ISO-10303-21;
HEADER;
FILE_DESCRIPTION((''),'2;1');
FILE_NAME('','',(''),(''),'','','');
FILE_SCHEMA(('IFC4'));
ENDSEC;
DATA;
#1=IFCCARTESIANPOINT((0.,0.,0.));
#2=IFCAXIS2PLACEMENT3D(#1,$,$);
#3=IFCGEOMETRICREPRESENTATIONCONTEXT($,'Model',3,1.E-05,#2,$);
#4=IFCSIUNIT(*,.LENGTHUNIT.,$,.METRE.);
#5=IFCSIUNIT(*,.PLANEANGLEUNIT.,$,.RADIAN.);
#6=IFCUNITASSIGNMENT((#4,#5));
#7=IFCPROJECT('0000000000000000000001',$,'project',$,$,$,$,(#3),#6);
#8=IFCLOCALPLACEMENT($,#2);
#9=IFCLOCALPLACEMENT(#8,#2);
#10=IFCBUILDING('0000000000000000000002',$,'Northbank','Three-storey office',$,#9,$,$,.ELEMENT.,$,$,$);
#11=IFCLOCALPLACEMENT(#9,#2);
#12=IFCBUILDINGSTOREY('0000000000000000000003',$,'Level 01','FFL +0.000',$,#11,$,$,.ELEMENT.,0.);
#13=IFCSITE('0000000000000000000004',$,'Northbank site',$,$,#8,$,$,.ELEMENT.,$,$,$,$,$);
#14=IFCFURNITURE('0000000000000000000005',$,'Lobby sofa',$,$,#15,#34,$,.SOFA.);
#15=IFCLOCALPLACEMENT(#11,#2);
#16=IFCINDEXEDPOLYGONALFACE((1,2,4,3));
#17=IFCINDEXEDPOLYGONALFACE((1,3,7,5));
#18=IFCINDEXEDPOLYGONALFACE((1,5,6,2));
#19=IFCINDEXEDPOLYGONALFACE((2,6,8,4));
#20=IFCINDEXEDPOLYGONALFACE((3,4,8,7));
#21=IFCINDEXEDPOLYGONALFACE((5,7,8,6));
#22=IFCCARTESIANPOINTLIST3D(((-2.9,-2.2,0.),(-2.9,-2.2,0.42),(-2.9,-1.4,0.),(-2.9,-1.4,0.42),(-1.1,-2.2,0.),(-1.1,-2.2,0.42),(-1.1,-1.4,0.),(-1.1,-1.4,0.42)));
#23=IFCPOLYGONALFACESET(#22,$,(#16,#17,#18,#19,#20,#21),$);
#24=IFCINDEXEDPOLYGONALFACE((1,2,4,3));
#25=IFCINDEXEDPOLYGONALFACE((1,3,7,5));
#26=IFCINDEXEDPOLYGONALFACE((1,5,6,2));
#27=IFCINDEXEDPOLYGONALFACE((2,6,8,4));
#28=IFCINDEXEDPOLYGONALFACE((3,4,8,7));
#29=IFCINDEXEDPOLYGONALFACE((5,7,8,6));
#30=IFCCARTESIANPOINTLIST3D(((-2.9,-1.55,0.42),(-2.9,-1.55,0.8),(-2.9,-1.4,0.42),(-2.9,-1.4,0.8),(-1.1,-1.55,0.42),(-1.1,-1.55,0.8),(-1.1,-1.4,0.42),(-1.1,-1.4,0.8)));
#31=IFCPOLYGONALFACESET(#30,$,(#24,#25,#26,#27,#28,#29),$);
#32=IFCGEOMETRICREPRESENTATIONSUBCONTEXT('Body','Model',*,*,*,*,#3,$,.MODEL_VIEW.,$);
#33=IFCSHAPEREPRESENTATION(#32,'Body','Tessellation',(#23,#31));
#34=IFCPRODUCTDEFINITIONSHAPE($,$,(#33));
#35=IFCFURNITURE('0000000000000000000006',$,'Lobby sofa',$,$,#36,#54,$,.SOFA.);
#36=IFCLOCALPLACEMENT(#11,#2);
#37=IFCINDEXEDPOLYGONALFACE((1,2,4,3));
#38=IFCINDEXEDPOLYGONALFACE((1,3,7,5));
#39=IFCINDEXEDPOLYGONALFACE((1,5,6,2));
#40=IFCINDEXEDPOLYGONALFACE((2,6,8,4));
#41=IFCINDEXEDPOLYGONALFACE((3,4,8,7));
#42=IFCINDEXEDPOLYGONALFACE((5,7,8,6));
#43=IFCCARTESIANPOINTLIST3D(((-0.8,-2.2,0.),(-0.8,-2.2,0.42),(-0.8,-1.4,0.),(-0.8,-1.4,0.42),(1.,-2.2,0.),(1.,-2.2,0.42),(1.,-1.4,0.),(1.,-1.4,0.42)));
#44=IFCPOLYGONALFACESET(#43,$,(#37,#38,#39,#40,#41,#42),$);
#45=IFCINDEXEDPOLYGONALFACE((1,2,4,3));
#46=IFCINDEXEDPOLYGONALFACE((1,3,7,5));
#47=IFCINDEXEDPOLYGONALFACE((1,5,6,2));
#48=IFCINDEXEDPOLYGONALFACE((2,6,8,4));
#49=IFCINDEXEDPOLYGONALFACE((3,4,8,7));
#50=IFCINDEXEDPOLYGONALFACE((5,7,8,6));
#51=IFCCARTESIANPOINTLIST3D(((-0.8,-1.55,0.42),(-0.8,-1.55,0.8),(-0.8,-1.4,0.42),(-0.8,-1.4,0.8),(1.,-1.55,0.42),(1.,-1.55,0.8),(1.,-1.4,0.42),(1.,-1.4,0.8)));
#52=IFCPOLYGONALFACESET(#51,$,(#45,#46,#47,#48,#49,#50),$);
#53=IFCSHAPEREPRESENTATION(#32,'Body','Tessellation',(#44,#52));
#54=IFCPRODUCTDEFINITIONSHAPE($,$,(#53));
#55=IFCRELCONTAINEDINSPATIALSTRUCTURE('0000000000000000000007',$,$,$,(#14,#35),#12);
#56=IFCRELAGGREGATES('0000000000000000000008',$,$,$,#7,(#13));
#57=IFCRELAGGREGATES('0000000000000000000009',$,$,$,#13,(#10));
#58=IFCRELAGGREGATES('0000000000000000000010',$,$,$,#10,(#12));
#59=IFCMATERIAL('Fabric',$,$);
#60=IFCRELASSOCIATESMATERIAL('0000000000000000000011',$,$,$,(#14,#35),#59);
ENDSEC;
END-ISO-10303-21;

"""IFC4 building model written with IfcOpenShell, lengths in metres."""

from ifc_helpers import new_model, si_unit, frame, origin, place, context, subcontext, project, spatial, rectangle, extrude, material, element, save


model = new_model("IFC4")

# Units and contexts
model_context = context("Model", 3, precision=1e-05, world=origin())
body_context = subcontext(model_context, "Body", "Model", "MODEL_VIEW")
ifc_project = project(units=[si_unit("LENGTHUNIT", "METRE"), si_unit("PLANEANGLEUNIT", "RADIAN")], contexts=[model_context])

# Site, building, storey
site_placement = place(None, origin())
site = spatial("IfcSite", under=ifc_project, at=site_placement, Name="Northbank site", CompositionType="ELEMENT")
building_placement = place(site_placement, origin())
building = spatial("IfcBuilding", under=site, at=building_placement, Name="Northbank", Description="Three-storey office", CompositionType="ELEMENT")
storey_placement = place(building_placement, origin())
storey = spatial("IfcBuildingStorey", under=building, at=storey_placement, Name="Level 01", Description="FFL +0.000", CompositionType="ELEMENT", Elevation=0.0)

# Furniture
ifc_material_1 = material(Name="Fabric")
furniture_1_placement = place(storey_placement, origin())
element("IfcFurniture", 1, at=furniture_1_placement, inside=storey, material=ifc_material_1, Name="Lobby sofa", PredefinedType="SOFA", context=body_context, shape_type="SweptSolid", body=[
    extrude(rectangle(XDim=1.8, YDim=0.8), frame((-2.0, -1.8, 0.0)), (0.0, 0.0, 1.0), 0.42),
    extrude(rectangle(XDim=1.8, YDim=0.15), frame((-2.0, -1.475, 0.42)), (0.0, 0.0, 1.0), 0.38),
])
furniture_2_placement = place(storey_placement, origin())
element("IfcFurniture", 2, at=furniture_2_placement, inside=storey, material=ifc_material_1, Name="Lobby sofa", PredefinedType="SOFA", context=body_context, shape_type="SweptSolid", body=[
    extrude(rectangle(XDim=1.8, YDim=0.8), frame((0.1, -1.8, 0.0)), (0.0, 0.0, 1.0), 0.42),
    extrude(rectangle(XDim=1.8, YDim=0.15), frame((0.1, -1.475, 0.42)), (0.0, 0.0, 1.0), 0.38),
])

save(model, "model.ifc")
